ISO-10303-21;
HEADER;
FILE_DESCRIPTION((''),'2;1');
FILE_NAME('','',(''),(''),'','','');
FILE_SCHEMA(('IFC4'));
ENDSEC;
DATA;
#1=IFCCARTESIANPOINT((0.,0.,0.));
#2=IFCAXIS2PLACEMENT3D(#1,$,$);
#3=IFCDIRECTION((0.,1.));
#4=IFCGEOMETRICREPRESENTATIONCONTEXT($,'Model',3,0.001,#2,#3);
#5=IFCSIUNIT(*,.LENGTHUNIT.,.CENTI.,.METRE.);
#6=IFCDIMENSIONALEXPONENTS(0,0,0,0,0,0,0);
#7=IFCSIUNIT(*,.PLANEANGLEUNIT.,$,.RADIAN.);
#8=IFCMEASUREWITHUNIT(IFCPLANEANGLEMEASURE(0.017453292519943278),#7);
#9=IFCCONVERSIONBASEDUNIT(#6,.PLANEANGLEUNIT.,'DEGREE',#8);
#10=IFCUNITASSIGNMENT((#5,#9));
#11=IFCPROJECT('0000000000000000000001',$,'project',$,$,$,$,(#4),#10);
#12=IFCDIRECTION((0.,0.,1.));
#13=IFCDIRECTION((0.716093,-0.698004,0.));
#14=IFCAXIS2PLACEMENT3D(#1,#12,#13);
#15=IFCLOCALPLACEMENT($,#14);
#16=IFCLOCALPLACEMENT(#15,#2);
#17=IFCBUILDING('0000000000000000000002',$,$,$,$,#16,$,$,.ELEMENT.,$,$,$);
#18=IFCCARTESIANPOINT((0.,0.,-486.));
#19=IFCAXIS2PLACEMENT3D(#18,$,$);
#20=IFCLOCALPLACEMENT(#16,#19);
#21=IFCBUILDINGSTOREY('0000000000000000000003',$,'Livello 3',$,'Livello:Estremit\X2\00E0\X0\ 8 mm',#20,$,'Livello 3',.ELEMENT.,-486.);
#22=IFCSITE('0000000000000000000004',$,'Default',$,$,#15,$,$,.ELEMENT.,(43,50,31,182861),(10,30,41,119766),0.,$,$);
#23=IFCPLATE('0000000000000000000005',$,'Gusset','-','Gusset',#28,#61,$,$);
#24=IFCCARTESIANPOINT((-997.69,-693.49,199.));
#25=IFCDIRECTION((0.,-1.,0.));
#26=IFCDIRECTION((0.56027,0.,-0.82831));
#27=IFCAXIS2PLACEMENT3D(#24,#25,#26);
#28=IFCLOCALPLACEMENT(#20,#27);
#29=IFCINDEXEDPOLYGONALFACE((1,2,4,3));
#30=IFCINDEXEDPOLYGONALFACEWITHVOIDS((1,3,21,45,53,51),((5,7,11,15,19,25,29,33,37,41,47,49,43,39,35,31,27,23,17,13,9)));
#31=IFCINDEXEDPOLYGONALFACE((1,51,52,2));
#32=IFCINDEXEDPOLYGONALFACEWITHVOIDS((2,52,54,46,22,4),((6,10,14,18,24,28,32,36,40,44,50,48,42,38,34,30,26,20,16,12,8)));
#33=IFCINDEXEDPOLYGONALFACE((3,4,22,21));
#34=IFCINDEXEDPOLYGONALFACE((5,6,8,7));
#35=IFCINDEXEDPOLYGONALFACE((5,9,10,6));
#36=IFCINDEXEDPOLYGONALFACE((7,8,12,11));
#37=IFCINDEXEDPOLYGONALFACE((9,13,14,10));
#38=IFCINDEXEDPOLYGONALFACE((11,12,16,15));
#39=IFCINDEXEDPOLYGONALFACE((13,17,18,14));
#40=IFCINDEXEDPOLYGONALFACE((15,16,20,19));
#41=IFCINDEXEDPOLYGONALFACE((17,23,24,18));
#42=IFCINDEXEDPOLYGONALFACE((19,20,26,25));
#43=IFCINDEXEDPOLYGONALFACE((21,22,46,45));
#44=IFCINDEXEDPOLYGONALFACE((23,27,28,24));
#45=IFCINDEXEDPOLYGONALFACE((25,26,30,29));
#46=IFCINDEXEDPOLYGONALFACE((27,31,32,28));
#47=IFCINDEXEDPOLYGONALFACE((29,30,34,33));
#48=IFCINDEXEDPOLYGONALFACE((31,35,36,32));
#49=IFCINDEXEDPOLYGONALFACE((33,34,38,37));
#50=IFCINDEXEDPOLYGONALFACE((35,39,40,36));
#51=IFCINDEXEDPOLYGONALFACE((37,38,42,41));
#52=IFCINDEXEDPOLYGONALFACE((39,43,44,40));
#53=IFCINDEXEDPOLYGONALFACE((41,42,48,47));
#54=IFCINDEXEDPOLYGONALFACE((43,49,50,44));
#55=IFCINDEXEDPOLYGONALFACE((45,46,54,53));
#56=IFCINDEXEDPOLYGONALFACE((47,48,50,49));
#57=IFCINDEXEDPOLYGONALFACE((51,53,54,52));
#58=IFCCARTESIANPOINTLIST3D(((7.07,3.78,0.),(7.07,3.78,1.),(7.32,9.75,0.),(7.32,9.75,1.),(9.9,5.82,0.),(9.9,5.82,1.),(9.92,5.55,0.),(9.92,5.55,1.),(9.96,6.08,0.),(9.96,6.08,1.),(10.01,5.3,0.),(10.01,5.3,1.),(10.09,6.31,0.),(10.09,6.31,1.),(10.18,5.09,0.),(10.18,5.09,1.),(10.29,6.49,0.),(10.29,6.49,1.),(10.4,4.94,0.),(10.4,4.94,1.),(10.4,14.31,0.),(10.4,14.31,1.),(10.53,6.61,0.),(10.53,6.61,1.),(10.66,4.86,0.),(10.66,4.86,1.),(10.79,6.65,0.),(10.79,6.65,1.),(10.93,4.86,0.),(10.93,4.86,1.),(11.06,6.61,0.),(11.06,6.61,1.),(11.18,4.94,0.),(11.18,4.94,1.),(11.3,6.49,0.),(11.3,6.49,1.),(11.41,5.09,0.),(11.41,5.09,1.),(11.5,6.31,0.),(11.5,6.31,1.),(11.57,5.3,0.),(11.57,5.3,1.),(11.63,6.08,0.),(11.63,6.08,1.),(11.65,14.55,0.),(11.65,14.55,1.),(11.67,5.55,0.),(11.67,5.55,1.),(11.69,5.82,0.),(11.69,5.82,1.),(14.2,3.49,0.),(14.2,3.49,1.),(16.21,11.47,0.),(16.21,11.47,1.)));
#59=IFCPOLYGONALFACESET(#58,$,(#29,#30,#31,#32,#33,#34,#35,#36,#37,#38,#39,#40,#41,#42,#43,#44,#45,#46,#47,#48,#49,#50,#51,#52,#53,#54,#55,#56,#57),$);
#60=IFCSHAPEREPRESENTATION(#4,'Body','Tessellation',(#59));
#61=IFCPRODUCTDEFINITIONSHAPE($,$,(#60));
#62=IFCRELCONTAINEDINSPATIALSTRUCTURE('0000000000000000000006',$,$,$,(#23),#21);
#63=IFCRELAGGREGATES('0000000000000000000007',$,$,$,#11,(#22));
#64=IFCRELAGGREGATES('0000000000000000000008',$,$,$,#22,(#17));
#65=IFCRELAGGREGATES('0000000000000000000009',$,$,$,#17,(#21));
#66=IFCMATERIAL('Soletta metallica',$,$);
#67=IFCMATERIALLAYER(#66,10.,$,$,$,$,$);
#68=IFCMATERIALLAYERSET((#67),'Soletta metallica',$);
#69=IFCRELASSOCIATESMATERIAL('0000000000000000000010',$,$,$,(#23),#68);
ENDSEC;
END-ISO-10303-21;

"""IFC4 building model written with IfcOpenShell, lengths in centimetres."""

from ifc_helpers import new_model, entity, si_unit, converted_unit, point, direction, frame, frame_2d, origin, origin_with_axes, origin_2d_with_axis, place, context, project, spatial, polyline, circle_curve, line_curve, trimmed, segment, composite_curve, circle, outline, extrude, material, layer, layer_set, element, save


model = new_model("IFC4")

# Units and contexts
model_context = context("Model", 3, precision=0.001, world=origin(), true_north=direction((0.0, 1.0)))
ifc_project = project(units=[si_unit("LENGTHUNIT", "METRE", prefix="CENTI"), converted_unit("PLANEANGLEUNIT", "DEGREE", entity("IfcPlaneAngleMeasure", 0.017453292519943278), si_unit("PLANEANGLEUNIT", "RADIAN"), dimensions=[0, 0, 0, 0, 0, 0, 0])], contexts=[model_context])

# Site, building, storey
site_placement = place(None, frame((0.0, 0.0, 0.0), z_axis=(0.0, 0.0, 1.0), x_axis=(0.716093, -0.698004, 0.0)))
site = spatial("IfcSite", under=ifc_project, at=site_placement, Name="Default", CompositionType="ELEMENT", RefLatitude=(43, 50, 31, 182861), RefLongitude=(10, 30, 41, 119766), RefElevation=0.0)
building_placement = place(site_placement, origin())
building = spatial("IfcBuilding", under=site, at=building_placement, CompositionType="ELEMENT")
storey_placement = place(building_placement, frame((0.0, 0.0, -486.0)))
storey = spatial("IfcBuildingStorey", under=building, at=storey_placement, Name="Livello 3", ObjectType="Livello:Estremità 8 mm", LongName="Livello 3", CompositionType="ELEMENT", Elevation=-486.0)

# Plate, openings
ifc_material_1 = material(Name="Soletta metallica")
ifc_layer_1 = layer(ifc_material_1, 10.0)
ifc_layer_set_1 = layer_set([ifc_layer_1], Name="Soletta metallica")
plate_1_placement = place(storey_placement, frame((-997.69, -693.49, 199.0), z_axis=(0.0, -1.0, 0.0), x_axis=(0.56027, 0.0, -0.82831)))
plate_1 = element("IfcPlate", 1, at=plate_1_placement, inside=storey, material=ifc_layer_set_1, Name="Gusset", Description="-", ObjectType="Gusset", context=model_context, shape_type="SweptSolid", body=[
    extrude(outline(polyline([(10.91, 15.05), (7.32, 9.75), (7.07, 3.78), (14.2, 3.49), (16.21, 11.47), (10.91, 15.05)])), origin_with_axes(), (0.0, 0.0, 1.0), 1.0),
])
opening_1_placement = place(plate_1_placement, frame((0.0, 0.0, 0.0), z_axis=(0.0, 0.0, 1.0), x_axis=(1.0, 0.0, 0.0)))
element("IfcOpeningElement", 2, at=opening_1_placement, cuts=plate_1, ObjectType="Opening", context=model_context, shape_type="SweptSolid", body=[
    extrude(outline(composite_curve([segment(trimmed(line_curve((10.91, 15.05), (-0.56027, -0.82831), 0.9), [point((10.91, 15.05))], [point((10.4, 14.31))], True, "CARTESIAN"), True, "CONTINUOUS"), segment(trimmed(circle_curve(frame_2d((11.15, 13.8), x_axis=(-1.0, 0.0)), 0.9), [point((10.4, 14.31))], [point((11.65, 14.55))], False, "CARTESIAN"), True, "CONTINUOUS"), segment(trimmed(line_curve((11.65, 14.55), (-0.82831, 0.56027), 0.9), [point((11.65, 14.55))], [point((10.91, 15.05))], True, "CARTESIAN"), True, "CONTINUOUS")], self_intersect="UNKNOWN")), origin(), (0.0, 0.0, 1.0), 1.0),
])
opening_2_placement = place(plate_1_placement, frame((10.79, 5.75, -0.05), z_axis=(0.0, 0.0, 1.0), x_axis=(0.0, 1.0, 0.0)))
element("IfcOpeningElement", 3, at=opening_2_placement, cuts=plate_1, ObjectType="Opening", context=model_context, shape_type="SweptSolid", body=[
    extrude(circle(Radius=0.9, at=origin_2d_with_axis()), origin(), (0.0, 0.0, 1.0), 1.1),
])

save(model, "model.ifc")
